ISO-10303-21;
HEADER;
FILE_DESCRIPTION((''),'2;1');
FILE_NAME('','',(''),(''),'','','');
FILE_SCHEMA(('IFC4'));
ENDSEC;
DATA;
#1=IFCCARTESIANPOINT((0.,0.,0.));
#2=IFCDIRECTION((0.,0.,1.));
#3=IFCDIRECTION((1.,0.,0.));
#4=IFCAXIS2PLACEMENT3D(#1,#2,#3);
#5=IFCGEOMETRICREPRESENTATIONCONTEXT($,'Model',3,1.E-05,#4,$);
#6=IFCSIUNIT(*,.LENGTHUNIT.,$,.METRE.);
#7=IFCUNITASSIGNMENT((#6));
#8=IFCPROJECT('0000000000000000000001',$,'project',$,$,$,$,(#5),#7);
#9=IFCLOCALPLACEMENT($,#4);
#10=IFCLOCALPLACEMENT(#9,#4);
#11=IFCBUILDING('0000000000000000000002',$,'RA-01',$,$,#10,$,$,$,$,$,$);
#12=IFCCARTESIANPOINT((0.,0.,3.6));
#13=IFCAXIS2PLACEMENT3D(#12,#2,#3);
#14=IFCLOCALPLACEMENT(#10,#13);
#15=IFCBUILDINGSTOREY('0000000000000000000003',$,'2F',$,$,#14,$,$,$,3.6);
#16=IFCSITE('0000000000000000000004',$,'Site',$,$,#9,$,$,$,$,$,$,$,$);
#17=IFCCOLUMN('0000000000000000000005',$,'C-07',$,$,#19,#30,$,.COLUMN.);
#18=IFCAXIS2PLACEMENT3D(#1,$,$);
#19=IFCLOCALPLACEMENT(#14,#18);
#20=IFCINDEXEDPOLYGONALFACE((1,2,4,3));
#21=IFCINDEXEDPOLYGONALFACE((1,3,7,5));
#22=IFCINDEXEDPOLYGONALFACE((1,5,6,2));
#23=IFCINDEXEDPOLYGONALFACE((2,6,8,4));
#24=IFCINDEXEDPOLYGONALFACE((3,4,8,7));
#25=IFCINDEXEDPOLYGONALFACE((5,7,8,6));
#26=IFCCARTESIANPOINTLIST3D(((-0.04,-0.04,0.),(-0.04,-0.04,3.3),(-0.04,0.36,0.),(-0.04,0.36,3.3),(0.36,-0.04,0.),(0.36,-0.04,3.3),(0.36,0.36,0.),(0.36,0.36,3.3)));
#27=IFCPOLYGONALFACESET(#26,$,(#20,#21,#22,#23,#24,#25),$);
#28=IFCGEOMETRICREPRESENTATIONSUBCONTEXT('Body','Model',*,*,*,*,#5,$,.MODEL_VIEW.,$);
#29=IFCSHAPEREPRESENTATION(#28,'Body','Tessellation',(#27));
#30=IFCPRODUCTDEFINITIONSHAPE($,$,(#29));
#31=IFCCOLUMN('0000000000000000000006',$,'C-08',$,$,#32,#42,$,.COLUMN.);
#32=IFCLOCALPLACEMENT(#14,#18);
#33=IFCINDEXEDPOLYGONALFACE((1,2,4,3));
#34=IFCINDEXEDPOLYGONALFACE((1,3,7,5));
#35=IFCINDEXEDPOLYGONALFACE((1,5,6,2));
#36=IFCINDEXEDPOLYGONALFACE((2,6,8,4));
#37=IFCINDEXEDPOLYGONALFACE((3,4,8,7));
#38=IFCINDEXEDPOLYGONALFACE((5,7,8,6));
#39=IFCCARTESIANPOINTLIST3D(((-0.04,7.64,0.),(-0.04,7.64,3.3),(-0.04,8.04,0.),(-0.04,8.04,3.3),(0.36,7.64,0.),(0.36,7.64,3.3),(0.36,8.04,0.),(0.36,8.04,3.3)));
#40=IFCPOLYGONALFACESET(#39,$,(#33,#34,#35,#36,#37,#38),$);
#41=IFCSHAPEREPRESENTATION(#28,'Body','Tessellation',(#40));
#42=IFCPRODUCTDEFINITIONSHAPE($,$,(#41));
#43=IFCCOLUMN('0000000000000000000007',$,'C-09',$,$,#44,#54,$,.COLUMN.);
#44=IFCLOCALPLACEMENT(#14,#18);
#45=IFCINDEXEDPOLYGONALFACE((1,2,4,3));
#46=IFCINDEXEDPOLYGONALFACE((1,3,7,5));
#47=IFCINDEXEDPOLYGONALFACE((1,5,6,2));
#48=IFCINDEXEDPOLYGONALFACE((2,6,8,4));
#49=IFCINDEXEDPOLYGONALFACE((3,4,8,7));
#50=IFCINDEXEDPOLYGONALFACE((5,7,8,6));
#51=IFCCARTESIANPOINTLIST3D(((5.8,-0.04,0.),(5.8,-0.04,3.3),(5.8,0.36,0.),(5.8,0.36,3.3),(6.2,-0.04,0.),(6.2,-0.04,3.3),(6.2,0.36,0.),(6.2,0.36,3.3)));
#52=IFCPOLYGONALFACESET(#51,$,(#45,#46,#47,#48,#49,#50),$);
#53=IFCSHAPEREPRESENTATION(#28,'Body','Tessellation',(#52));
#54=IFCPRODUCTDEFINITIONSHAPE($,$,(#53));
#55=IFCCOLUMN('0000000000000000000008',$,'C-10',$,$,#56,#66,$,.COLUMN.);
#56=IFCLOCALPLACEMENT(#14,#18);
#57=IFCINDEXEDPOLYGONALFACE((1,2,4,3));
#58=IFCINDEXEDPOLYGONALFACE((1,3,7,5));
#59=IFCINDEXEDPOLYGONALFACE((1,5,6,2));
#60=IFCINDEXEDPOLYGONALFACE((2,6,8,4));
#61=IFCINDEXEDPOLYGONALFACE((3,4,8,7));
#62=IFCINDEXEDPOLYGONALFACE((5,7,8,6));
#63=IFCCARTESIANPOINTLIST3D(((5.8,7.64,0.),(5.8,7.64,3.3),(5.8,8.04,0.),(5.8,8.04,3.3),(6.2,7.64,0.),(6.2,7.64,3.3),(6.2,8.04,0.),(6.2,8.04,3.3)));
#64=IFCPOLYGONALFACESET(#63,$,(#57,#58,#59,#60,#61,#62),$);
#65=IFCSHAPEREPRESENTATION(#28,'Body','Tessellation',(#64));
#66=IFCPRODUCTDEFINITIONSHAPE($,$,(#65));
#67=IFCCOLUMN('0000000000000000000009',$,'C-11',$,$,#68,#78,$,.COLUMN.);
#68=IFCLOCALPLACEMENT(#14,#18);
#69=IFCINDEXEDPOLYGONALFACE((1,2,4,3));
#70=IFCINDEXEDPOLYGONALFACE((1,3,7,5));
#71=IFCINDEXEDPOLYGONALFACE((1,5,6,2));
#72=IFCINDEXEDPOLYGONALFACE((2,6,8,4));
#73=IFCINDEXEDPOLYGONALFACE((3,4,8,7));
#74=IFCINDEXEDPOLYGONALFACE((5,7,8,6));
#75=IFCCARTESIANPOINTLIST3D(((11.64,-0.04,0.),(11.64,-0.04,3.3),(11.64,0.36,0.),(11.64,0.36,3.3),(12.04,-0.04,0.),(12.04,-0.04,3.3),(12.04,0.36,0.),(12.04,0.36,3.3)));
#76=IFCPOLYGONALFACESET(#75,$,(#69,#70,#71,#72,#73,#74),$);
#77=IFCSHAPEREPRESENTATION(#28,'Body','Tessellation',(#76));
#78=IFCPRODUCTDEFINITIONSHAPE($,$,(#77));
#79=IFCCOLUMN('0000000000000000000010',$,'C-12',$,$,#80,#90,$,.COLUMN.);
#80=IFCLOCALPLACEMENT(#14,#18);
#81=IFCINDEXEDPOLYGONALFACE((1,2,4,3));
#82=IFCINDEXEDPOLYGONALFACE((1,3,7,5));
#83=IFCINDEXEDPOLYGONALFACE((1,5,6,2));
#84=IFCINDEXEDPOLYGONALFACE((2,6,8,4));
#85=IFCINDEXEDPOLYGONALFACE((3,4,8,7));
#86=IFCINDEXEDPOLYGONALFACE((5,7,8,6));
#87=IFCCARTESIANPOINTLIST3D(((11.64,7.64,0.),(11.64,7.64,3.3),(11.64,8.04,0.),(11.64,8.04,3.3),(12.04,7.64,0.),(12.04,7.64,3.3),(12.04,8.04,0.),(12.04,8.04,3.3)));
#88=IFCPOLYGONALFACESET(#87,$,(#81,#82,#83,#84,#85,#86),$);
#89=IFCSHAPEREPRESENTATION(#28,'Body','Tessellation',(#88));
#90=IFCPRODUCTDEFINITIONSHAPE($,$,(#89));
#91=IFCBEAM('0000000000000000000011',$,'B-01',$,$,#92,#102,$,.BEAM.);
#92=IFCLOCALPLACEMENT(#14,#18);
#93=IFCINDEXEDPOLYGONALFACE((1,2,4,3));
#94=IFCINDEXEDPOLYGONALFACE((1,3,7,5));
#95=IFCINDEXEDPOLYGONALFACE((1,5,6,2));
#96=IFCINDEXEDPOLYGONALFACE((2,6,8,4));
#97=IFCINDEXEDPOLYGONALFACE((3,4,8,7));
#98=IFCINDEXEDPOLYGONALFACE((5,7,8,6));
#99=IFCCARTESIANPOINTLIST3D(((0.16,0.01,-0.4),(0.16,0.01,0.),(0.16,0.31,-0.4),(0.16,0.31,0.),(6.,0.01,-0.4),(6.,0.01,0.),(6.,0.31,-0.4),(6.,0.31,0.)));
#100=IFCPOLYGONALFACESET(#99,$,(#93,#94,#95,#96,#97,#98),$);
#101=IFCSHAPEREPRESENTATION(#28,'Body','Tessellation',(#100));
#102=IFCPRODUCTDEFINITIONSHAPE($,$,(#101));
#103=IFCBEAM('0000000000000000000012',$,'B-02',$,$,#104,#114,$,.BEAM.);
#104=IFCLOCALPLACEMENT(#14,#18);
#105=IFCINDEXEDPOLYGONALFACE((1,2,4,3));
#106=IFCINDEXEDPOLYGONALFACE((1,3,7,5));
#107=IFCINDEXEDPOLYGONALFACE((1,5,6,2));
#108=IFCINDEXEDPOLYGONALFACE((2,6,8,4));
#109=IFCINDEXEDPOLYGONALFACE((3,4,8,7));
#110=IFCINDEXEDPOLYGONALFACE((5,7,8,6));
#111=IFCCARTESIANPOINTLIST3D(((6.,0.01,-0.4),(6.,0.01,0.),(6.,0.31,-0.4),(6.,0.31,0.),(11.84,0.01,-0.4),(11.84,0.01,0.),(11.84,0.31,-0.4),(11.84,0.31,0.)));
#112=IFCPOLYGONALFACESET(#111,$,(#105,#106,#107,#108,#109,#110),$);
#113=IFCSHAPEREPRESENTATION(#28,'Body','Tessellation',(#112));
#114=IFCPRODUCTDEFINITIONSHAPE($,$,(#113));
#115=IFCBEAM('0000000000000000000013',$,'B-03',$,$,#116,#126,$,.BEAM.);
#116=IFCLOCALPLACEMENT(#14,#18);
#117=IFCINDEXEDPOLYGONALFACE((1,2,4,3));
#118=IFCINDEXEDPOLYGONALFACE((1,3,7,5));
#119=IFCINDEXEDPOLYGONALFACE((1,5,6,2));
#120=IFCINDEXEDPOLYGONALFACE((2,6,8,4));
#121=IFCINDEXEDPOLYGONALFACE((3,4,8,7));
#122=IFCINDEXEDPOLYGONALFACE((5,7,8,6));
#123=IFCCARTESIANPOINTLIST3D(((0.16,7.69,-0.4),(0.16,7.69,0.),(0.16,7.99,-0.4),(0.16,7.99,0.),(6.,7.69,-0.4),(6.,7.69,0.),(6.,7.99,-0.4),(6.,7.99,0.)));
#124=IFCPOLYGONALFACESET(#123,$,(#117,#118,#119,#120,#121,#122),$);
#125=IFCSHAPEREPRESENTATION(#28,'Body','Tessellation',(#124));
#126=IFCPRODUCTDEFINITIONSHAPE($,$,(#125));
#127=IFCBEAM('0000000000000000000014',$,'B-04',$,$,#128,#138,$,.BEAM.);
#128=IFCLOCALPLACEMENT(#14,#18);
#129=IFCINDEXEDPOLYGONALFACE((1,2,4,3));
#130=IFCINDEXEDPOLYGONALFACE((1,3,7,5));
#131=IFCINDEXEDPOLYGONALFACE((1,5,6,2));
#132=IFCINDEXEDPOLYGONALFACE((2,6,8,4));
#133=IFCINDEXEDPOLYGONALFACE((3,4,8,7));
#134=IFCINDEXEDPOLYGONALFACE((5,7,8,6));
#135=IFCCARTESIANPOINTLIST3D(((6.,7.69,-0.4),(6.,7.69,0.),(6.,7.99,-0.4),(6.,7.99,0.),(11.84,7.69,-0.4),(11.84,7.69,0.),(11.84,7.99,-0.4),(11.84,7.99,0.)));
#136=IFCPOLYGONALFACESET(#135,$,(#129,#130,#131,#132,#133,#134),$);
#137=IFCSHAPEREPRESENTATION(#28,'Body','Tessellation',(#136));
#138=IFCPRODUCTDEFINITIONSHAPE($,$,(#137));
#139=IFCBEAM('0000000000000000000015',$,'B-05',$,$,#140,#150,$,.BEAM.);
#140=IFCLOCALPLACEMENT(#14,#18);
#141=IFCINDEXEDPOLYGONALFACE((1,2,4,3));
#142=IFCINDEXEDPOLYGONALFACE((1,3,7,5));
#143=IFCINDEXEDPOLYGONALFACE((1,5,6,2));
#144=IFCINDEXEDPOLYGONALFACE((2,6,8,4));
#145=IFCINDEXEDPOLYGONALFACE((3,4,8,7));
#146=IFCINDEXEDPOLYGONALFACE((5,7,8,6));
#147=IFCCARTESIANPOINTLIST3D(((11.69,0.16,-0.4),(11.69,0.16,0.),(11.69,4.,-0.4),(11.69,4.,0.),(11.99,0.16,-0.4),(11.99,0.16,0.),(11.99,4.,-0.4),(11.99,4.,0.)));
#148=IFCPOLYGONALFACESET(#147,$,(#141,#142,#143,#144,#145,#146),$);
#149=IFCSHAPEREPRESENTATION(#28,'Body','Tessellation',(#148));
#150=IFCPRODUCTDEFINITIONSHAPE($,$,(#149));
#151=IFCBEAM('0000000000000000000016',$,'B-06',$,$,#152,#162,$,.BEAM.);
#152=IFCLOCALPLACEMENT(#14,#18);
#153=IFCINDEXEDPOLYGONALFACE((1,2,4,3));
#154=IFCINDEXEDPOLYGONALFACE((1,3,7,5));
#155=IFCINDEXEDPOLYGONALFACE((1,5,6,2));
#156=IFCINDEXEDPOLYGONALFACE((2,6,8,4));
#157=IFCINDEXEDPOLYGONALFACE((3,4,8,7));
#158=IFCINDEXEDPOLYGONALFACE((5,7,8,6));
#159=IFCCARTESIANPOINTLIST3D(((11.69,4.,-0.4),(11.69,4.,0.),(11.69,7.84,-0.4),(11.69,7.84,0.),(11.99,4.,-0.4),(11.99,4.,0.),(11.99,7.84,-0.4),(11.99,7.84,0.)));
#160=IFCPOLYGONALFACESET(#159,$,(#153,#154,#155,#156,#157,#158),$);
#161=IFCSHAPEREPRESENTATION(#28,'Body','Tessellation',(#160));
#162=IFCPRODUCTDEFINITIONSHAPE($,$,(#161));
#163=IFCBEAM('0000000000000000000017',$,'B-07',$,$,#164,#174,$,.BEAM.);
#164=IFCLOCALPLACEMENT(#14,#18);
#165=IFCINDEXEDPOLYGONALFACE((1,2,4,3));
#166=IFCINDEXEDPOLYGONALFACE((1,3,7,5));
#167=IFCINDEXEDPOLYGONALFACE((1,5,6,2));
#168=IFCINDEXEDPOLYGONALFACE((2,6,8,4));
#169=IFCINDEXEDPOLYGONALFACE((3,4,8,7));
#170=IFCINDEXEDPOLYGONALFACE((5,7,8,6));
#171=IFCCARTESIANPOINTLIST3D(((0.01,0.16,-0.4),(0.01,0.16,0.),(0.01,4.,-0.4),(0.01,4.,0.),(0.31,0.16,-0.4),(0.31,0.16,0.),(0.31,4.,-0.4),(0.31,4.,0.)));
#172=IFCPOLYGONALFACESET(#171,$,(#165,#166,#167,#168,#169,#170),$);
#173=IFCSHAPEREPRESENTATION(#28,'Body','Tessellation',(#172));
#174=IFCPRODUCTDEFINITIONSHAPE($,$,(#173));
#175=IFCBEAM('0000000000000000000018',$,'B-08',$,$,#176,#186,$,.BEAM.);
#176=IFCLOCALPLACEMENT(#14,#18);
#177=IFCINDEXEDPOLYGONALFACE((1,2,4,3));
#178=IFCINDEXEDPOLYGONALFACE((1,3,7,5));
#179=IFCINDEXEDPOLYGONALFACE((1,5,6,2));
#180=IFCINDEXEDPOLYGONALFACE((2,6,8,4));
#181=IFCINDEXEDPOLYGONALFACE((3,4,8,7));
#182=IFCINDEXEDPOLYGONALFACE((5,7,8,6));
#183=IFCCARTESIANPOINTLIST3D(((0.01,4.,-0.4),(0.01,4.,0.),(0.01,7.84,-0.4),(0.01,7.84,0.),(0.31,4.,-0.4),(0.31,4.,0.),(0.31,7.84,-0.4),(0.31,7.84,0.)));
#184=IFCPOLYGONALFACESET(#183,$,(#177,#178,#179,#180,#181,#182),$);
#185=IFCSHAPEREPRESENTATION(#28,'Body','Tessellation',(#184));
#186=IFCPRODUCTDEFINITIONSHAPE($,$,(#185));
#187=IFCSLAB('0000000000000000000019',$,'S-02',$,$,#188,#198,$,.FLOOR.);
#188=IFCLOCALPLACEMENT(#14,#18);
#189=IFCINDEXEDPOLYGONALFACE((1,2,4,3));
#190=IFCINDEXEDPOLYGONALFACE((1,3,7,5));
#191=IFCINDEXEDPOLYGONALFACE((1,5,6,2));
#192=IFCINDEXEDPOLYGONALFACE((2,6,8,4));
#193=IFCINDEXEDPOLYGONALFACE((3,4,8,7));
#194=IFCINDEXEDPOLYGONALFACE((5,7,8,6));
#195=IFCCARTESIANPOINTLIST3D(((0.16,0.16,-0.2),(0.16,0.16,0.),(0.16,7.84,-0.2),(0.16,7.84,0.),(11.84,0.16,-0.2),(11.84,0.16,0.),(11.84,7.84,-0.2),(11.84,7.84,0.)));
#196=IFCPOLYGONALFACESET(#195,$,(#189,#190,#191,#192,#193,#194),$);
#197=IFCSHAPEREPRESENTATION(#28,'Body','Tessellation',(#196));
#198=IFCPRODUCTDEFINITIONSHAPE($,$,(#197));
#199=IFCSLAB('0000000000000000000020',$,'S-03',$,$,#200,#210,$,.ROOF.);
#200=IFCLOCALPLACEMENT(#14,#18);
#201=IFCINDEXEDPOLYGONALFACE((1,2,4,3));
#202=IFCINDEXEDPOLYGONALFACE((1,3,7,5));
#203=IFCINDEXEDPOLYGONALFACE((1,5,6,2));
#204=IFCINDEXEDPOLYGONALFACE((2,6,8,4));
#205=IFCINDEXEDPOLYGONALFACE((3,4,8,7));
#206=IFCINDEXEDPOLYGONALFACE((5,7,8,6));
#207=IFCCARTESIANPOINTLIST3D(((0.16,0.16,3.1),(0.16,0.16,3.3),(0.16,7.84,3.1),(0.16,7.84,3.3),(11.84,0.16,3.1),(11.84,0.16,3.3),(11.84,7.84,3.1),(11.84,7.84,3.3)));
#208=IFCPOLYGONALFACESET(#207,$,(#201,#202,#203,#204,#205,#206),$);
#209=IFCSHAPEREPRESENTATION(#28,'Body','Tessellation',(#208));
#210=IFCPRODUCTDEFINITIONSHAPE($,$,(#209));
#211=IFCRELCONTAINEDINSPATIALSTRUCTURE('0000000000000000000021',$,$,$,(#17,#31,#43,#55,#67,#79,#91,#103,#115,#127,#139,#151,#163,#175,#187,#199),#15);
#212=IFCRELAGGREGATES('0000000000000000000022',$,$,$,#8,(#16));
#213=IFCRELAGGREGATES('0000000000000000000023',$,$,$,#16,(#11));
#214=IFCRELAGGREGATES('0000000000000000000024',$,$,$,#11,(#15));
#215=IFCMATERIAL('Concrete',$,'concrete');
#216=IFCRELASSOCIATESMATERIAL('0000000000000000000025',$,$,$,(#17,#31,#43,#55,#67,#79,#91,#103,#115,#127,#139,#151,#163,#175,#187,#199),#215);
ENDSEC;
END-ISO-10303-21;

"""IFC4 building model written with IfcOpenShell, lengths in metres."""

from ifc_helpers import new_model, si_unit, frame, origin_with_axes, origin_2d_with_axis, place, context, subcontext, project, spatial, polyline, rectangle, outline, extrude, material, element, save


model = new_model("IFC4")

# Units and contexts
model_context = context("Model", 3, precision=1e-05, world=origin_with_axes())
body_context = subcontext(model_context, "Body", "Model", "MODEL_VIEW")
ifc_project = project(units=[si_unit("LENGTHUNIT", "METRE")], contexts=[model_context])

# Site, building, storey
site_placement = place(None, origin_with_axes())
site = spatial("IfcSite", under=ifc_project, at=site_placement, Name="Site")
building_placement = place(site_placement, origin_with_axes())
building = spatial("IfcBuilding", under=site, at=building_placement, Name="RA-01")
storey_placement = place(building_placement, frame((0.0, 0.0, 3.6), z_axis=(0.0, 0.0, 1.0), x_axis=(1.0, 0.0, 0.0)))
storey = spatial("IfcBuildingStorey", under=building, at=storey_placement, Name="2F", Elevation=3.6)

# Columns
ifc_material_1 = material(Name="Concrete", Category="concrete")
for number, where, z_axis, x_axis, name in (
    (1, (0.16, 0.16, 0.0), (0.0, 0.0, 1.0), (1.0, 0.0, 0.0), "C-07"),
    (2, (0.16, 7.84, 0.0), (0.0, 0.0, 1.0), (1.0, 0.0, 0.0), "C-08"),
    (3, (6.0, 0.16, 0.0), (0.0, 0.0, 1.0), (1.0, 0.0, 0.0), "C-09"),
    (4, (6.0, 7.84, 0.0), (0.0, 0.0, 1.0), (1.0, 0.0, 0.0), "C-10"),
    (5, (11.84, 0.16, 0.0), (0.0, 0.0, 1.0), (1.0, 0.0, 0.0), "C-11"),
    (6, (11.84, 7.84, 0.0), (0.0, 0.0, 1.0), (1.0, 0.0, 0.0), "C-12"),
):
    element("IfcColumn", number, at=place(storey_placement, frame(where, z_axis=z_axis, x_axis=x_axis)), inside=storey, material=ifc_material_1, Name=name, PredefinedType="COLUMN", context=body_context, shape_type="SweptSolid", body=[
        extrude(rectangle(XDim=0.4, YDim=0.4, at=origin_2d_with_axis()), origin_with_axes(), (0.0, 0.0, 1.0), 3.3),
    ])

# Beams
for number, where, z_axis, x_axis, name in (
    (7, (0.16, 0.16, -0.2), (1.0, 0.0, 0.0), (0.0, 1.0, 0.0), "B-01"),
    (8, (6.0, 0.16, -0.2), (1.0, 0.0, 0.0), (0.0, 1.0, 0.0), "B-02"),
    (9, (0.16, 7.84, -0.2), (1.0, 0.0, 0.0), (0.0, 1.0, 0.0), "B-03"),
    (10, (6.0, 7.84, -0.2), (1.0, 0.0, 0.0), (0.0, 1.0, 0.0), "B-04"),
):
    element("IfcBeam", number, at=place(storey_placement, frame(where, z_axis=z_axis, x_axis=x_axis)), inside=storey, material=ifc_material_1, Name=name, PredefinedType="BEAM", context=body_context, shape_type="SweptSolid", body=[
        extrude(rectangle(XDim=0.3, YDim=0.4, at=origin_2d_with_axis()), origin_with_axes(), (0.0, 0.0, 1.0), 5.84),
    ])
for number, where, z_axis, x_axis, name in (
    (11, (11.84, 0.16, -0.2), (0.0, 1.0, 0.0), (-1.0, 0.0, 0.0), "B-05"),
    (12, (11.84, 4.0, -0.2), (0.0, 1.0, 0.0), (-1.0, 0.0, 0.0), "B-06"),
    (13, (0.16, 0.16, -0.2), (0.0, 1.0, 0.0), (-1.0, 0.0, 0.0), "B-07"),
    (14, (0.16, 4.0, -0.2), (0.0, 1.0, 0.0), (-1.0, 0.0, 0.0), "B-08"),
):
    element("IfcBeam", number, at=place(storey_placement, frame(where, z_axis=z_axis, x_axis=x_axis)), inside=storey, material=ifc_material_1, Name=name, PredefinedType="BEAM", context=body_context, shape_type="SweptSolid", body=[
        extrude(rectangle(XDim=0.3, YDim=0.4, at=origin_2d_with_axis()), origin_with_axes(), (0.0, 0.0, 1.0), 3.84),
    ])

# Slabs
slab_1_placement = place(storey_placement, frame((0.0, 0.0, -0.2), z_axis=(0.0, 0.0, 1.0), x_axis=(1.0, 0.0, 0.0)))
element("IfcSlab", 15, at=slab_1_placement, inside=storey, material=ifc_material_1, Name="S-02", PredefinedType="FLOOR", context=body_context, shape_type="SweptSolid", body=[
    extrude(outline(polyline([(0.16, 0.16), (11.84, 0.16), (11.84, 7.84), (0.16, 7.84), (0.16, 0.16)])), origin_with_axes(), (0.0, 0.0, 1.0), 0.2),
])
slab_2_placement = place(storey_placement, frame((0.0, 0.0, 3.1), z_axis=(0.0, 0.0, 1.0), x_axis=(1.0, 0.0, 0.0)))
element("IfcSlab", 16, at=slab_2_placement, inside=storey, material=ifc_material_1, Name="S-03", PredefinedType="ROOF", context=body_context, shape_type="SweptSolid", body=[
    extrude(outline(polyline([(0.16, 0.16), (11.84, 0.16), (11.84, 7.84), (0.16, 7.84), (0.16, 0.16)])), origin_with_axes(), (0.0, 0.0, 1.0), 0.2),
])

save(model, "model.ifc")
